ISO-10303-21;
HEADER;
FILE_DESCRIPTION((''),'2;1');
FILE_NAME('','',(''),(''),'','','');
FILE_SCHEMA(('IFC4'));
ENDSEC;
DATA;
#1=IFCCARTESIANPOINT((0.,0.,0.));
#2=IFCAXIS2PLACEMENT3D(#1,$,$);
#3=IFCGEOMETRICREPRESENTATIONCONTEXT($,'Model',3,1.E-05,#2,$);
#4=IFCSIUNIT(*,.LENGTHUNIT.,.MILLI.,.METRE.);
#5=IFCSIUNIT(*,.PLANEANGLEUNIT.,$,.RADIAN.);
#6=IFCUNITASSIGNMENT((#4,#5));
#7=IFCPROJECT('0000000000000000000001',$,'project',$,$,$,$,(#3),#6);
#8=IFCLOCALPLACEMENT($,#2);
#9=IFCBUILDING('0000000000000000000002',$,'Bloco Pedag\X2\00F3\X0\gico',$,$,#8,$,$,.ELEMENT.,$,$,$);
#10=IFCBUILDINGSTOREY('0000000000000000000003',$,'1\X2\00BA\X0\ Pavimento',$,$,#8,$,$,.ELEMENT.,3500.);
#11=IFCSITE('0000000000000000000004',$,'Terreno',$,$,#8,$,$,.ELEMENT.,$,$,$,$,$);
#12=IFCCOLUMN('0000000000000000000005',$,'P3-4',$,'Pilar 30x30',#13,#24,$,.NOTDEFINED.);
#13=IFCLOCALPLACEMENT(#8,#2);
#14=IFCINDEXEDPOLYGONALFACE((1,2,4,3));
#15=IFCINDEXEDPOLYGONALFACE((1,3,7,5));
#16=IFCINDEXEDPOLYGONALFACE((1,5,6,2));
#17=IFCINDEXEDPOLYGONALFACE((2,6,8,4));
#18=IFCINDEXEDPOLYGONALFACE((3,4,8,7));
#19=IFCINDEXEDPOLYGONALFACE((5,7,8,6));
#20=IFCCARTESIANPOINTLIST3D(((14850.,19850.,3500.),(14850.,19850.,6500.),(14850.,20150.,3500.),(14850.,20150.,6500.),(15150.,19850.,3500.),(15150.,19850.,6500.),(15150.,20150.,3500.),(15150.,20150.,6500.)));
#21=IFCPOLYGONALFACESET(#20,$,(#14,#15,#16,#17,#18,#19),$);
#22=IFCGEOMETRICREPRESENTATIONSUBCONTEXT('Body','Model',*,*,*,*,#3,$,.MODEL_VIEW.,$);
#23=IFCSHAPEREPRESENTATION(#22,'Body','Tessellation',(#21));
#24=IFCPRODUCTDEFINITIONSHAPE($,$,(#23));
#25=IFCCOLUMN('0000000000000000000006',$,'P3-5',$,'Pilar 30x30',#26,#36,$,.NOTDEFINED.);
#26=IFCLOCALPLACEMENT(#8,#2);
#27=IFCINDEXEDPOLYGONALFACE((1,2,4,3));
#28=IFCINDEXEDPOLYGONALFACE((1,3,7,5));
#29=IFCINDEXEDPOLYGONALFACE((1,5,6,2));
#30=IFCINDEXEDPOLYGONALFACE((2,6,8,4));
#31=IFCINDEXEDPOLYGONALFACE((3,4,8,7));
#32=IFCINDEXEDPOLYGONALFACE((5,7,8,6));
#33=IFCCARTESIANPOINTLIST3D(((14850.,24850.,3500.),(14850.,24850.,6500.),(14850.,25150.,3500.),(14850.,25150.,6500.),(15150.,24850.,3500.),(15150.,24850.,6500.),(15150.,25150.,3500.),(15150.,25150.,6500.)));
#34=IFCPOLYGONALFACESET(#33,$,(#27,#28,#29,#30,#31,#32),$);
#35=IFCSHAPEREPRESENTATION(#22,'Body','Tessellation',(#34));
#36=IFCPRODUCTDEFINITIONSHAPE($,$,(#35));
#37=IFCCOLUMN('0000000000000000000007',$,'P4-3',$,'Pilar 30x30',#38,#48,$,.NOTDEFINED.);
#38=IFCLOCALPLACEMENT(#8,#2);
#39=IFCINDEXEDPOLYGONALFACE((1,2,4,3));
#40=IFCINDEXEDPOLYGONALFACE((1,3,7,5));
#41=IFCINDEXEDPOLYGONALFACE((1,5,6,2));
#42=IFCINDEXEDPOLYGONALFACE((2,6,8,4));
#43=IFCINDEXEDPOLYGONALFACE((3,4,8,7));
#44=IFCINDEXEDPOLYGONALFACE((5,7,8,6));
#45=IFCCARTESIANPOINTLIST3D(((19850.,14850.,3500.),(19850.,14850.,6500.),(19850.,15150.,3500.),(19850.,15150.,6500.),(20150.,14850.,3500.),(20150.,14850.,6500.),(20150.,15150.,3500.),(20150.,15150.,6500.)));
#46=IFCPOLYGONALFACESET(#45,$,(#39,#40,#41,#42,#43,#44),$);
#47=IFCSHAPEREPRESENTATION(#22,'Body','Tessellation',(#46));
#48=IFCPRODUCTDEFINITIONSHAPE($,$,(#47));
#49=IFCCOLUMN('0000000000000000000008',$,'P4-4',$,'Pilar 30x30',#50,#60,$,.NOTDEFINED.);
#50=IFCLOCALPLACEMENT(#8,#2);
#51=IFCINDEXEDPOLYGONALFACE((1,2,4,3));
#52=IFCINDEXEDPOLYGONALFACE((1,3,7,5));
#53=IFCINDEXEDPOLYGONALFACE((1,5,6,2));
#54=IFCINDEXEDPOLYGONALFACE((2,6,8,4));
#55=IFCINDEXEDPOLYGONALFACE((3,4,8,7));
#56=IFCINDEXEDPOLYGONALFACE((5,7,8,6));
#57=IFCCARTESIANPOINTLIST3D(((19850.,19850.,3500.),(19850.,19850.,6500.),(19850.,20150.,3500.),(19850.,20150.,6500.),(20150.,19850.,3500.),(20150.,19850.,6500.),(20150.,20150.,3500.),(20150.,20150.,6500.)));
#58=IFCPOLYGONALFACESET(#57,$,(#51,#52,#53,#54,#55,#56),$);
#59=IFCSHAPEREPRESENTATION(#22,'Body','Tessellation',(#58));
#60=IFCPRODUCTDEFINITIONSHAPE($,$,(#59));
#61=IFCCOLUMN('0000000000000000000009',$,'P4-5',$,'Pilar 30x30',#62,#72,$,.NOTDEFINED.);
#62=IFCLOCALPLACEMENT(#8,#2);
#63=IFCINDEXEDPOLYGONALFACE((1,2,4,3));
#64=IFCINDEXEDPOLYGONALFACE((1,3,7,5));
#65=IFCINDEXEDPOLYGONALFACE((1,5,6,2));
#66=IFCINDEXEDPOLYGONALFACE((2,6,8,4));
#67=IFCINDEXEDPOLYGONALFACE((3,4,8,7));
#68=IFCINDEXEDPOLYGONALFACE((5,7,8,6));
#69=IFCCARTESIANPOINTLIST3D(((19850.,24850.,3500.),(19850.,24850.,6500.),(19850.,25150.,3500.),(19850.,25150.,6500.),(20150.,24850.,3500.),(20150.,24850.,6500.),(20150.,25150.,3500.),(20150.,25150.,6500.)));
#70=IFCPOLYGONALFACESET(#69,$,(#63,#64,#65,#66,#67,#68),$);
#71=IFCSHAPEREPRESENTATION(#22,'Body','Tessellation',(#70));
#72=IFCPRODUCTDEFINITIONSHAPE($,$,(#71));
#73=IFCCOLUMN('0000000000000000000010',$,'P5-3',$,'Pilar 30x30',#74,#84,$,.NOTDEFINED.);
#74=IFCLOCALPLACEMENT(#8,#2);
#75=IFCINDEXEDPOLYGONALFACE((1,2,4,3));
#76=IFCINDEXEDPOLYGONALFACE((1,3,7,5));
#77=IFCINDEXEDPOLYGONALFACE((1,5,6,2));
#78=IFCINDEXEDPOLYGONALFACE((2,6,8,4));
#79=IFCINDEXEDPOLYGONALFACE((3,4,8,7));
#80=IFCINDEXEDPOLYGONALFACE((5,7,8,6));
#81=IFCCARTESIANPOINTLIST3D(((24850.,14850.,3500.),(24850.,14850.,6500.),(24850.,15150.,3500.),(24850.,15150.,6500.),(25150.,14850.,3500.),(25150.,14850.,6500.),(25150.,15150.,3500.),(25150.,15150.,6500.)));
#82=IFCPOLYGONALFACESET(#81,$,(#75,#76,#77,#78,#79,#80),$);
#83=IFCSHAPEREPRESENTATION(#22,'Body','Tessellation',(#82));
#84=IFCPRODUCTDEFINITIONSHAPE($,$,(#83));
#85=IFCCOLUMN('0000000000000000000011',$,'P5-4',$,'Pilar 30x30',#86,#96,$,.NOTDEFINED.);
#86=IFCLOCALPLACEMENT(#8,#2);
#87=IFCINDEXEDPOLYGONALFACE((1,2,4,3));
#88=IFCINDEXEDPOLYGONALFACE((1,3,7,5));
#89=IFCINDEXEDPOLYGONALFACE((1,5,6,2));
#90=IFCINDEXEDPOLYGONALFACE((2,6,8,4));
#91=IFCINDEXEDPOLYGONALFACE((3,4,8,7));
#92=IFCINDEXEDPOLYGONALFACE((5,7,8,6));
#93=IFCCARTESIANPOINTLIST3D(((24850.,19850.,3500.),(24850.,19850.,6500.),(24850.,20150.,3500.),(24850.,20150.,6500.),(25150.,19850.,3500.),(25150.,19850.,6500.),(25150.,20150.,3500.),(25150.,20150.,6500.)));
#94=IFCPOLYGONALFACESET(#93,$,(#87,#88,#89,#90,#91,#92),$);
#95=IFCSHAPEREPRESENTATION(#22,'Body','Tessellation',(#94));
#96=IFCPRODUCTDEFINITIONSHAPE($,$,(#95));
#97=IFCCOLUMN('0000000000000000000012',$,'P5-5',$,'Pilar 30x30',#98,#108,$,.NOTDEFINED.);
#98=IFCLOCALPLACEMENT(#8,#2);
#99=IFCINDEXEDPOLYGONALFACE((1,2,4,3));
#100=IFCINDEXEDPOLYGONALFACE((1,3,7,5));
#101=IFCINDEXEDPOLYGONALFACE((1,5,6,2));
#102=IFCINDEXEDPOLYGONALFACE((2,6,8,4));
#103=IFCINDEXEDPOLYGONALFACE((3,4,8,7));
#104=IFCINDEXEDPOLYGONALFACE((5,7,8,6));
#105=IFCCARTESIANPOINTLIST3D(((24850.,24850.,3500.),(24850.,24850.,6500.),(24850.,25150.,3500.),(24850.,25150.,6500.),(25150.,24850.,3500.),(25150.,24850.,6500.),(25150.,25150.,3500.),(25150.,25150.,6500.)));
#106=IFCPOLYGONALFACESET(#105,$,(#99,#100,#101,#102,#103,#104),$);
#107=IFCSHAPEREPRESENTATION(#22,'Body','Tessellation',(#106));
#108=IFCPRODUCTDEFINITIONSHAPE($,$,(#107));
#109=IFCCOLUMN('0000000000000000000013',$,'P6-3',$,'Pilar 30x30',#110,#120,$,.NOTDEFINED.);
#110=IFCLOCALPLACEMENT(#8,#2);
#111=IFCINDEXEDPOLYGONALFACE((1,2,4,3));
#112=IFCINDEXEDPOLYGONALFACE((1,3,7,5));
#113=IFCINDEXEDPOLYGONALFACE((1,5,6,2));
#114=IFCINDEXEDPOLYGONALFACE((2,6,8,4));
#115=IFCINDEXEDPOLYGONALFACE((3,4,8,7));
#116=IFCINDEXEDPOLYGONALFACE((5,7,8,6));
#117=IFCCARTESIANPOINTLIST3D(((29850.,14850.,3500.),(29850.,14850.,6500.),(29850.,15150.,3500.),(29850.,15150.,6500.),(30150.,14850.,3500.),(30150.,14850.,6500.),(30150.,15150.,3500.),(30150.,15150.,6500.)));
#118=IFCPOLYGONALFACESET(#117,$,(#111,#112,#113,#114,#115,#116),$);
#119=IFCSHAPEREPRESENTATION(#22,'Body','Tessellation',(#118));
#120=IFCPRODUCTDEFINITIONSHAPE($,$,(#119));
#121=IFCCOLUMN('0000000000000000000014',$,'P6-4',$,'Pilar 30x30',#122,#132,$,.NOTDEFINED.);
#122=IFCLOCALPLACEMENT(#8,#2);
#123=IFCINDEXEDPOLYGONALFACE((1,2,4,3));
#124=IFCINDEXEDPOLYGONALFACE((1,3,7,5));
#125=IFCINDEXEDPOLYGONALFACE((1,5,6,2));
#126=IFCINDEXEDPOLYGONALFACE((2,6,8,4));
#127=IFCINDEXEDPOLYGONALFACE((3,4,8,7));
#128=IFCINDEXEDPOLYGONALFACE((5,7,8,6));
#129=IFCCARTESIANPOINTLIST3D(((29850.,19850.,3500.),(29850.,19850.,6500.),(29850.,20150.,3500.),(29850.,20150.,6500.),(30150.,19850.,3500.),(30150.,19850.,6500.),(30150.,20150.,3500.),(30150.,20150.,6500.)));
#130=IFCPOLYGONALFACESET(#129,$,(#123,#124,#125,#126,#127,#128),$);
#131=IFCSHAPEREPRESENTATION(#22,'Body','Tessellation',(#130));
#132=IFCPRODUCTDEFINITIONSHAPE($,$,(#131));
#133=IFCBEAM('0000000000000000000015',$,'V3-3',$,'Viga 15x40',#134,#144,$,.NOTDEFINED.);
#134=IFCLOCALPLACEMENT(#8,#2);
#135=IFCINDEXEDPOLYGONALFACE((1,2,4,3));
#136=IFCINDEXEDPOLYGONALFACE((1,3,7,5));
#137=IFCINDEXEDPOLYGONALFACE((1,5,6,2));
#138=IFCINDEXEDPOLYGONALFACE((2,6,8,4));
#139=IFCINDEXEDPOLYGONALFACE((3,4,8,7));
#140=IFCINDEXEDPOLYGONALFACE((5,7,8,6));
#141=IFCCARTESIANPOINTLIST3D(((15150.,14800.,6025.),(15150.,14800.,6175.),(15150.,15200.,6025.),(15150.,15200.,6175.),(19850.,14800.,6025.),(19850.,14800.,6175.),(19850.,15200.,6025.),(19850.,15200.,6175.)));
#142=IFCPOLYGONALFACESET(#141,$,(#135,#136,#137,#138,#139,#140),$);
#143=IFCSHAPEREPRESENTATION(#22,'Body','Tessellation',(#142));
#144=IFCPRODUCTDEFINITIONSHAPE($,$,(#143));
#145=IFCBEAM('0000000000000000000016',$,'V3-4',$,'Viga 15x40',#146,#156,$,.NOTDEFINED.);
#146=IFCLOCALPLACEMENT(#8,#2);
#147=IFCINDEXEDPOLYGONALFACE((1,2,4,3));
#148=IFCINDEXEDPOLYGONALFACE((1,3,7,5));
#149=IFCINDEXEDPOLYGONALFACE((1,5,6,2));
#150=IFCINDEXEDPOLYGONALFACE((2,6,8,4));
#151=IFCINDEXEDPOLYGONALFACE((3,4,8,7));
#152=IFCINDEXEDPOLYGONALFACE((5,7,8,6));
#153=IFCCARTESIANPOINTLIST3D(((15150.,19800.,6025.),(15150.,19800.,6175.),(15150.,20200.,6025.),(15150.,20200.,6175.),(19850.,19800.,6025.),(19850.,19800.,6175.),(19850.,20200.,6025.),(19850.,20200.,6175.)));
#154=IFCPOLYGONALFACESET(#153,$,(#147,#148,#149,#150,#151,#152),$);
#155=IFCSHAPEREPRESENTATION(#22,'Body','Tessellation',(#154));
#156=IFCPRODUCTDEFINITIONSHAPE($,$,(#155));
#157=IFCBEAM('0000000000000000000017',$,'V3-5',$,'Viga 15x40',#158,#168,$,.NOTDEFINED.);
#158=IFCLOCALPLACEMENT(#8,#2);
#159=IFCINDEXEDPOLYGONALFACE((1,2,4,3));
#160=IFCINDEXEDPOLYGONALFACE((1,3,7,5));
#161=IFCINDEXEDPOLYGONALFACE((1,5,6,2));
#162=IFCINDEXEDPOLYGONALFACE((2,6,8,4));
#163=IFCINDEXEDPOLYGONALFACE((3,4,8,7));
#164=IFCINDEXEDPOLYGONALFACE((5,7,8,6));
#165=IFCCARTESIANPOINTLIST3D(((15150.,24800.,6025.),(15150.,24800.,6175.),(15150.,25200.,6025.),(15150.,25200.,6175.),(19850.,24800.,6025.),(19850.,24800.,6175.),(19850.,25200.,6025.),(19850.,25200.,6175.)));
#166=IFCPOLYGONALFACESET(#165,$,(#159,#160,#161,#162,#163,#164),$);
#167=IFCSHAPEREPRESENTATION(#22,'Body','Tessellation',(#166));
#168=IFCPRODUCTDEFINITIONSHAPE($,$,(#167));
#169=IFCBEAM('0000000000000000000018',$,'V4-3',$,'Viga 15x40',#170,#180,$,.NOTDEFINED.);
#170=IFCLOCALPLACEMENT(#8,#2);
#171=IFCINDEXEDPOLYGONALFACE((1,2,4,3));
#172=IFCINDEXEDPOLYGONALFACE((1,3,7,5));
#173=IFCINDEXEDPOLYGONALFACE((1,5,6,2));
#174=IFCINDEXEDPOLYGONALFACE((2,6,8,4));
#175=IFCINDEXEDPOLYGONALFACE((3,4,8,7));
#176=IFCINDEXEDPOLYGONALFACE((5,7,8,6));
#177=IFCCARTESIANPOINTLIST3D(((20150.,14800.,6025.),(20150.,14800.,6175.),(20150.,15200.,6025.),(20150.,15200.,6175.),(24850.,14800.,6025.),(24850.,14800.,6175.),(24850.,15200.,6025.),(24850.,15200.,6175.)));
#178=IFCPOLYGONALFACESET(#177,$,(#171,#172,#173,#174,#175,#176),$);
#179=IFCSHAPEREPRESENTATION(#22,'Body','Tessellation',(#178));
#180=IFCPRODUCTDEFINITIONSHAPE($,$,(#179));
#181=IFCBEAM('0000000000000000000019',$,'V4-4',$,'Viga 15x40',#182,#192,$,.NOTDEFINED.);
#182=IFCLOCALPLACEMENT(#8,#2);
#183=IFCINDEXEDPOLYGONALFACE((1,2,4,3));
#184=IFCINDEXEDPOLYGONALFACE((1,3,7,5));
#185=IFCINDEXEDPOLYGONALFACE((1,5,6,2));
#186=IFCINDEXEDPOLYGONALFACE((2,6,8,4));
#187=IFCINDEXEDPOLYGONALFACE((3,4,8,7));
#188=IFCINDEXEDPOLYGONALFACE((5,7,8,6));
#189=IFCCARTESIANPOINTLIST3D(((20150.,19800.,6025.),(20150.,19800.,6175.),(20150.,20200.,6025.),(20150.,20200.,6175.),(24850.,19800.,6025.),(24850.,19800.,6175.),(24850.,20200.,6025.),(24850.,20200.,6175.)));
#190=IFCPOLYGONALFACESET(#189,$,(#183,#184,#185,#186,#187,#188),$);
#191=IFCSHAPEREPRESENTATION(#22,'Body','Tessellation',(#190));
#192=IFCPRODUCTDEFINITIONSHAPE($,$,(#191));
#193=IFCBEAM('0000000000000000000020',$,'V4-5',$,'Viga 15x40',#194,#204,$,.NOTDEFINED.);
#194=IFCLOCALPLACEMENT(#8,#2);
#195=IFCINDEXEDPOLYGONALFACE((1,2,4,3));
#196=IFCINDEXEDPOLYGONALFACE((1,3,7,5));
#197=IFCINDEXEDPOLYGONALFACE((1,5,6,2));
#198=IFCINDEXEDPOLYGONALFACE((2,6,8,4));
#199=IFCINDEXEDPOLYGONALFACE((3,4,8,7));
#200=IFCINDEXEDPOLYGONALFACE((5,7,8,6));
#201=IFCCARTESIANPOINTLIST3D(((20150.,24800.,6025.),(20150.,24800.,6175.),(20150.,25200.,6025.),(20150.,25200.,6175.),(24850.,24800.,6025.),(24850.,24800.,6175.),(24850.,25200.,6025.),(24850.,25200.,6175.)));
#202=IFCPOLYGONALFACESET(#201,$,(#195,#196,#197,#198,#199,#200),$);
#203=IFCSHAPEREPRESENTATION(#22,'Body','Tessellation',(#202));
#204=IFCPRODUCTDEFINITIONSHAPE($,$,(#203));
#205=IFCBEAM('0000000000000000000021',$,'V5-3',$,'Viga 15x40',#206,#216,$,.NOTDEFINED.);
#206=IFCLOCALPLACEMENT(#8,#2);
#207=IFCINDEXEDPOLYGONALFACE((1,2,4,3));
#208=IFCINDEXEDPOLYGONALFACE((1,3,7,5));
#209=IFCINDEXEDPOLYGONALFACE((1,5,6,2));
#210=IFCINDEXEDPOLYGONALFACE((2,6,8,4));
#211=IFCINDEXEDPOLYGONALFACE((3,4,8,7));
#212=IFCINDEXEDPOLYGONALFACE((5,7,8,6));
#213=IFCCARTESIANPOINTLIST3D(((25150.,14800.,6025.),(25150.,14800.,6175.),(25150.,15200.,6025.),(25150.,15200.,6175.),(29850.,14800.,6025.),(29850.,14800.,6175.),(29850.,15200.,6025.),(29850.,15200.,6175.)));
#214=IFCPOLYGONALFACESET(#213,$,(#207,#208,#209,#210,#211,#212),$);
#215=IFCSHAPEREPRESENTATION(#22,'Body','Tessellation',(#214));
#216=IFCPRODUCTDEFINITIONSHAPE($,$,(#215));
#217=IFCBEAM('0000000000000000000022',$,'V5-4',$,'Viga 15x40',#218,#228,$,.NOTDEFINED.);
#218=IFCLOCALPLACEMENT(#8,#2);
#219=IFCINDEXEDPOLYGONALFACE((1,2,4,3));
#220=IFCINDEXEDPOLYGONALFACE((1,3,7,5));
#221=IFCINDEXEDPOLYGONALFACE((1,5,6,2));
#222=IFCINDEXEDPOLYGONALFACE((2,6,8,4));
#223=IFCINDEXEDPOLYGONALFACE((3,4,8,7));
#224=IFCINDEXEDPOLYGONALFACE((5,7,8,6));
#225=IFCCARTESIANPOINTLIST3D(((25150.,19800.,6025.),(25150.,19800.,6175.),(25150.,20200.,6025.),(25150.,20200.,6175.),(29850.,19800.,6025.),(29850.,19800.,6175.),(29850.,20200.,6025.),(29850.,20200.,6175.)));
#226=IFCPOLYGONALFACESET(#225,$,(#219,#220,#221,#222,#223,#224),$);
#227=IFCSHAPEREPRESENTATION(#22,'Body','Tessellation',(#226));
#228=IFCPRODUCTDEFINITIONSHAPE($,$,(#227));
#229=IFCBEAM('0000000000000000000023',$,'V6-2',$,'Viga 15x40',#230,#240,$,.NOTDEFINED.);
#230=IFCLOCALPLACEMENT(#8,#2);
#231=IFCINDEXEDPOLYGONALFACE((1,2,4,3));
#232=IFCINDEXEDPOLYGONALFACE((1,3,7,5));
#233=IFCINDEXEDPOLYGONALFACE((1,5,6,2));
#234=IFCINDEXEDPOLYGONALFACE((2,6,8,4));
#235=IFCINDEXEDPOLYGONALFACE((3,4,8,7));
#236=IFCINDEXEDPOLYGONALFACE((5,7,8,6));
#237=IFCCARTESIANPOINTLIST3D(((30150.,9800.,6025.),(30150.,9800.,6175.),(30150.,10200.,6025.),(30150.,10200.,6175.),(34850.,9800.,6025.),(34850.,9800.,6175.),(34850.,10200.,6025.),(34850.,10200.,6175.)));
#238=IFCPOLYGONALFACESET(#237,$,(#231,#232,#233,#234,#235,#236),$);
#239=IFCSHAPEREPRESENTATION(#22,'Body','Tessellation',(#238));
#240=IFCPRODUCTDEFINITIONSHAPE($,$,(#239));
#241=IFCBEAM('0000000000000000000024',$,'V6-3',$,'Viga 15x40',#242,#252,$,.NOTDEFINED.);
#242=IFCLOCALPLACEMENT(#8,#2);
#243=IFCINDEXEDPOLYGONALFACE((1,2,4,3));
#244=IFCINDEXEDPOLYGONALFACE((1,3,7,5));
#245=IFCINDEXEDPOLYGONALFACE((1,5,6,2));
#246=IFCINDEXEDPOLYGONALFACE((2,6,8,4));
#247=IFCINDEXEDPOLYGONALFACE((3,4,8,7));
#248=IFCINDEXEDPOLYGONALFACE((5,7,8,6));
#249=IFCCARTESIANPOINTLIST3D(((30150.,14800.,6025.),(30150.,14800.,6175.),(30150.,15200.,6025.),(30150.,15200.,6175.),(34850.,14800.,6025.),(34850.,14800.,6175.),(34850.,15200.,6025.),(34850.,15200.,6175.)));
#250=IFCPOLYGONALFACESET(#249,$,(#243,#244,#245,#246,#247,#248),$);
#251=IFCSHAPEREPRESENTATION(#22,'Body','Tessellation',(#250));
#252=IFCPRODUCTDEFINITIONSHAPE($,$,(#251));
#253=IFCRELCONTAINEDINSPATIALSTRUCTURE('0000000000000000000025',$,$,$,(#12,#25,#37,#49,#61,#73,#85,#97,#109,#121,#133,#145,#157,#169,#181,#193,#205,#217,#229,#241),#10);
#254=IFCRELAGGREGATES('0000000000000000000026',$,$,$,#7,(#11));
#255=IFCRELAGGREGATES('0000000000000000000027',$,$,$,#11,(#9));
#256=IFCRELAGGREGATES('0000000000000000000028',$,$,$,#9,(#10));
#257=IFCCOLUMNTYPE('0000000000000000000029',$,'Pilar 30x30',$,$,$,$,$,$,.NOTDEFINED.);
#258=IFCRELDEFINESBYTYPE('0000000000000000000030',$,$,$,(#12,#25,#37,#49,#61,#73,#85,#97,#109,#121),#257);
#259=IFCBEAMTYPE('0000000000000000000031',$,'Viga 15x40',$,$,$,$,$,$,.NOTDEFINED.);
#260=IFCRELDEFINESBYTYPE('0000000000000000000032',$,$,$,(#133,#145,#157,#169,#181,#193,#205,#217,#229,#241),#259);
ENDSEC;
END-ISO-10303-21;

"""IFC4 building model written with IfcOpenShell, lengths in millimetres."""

from ifc_helpers import new_model, si_unit, frame, origin, origin_2d, place, context, subcontext, project, spatial, rectangle, extrude, type_object, element, save


model = new_model("IFC4")

# Units and contexts
model_context = context("Model", 3, precision=1e-05, world=origin())
body_context = subcontext(model_context, "Body", "Model", "MODEL_VIEW")
ifc_project = project(units=[si_unit("LENGTHUNIT", "METRE", prefix="MILLI"), si_unit("PLANEANGLEUNIT", "RADIAN")], contexts=[model_context])

# Site, building, storey
placement = place(None, origin())
site = spatial("IfcSite", under=ifc_project, at=placement, Name="Terreno", CompositionType="ELEMENT")
building = spatial("IfcBuilding", under=site, at=placement, Name="Bloco Pedagógico", CompositionType="ELEMENT")
storey = spatial("IfcBuildingStorey", under=building, at=placement, Name="1º Pavimento", CompositionType="ELEMENT", Elevation=3500.0)

# Columns
column_type = type_object("IfcColumnType", Name="Pilar 30x30", PredefinedType="NOTDEFINED")
for number, where, z_axis, x_axis, name in (
    (1, (15000.0, 20000.0, 3500.0), (0.0, 0.0, 1.0), (1.0, 0.0, 0.0), "P3-4"),
    (2, (15000.0, 25000.0, 3500.0), (0.0, 0.0, 1.0), (1.0, 0.0, 0.0), "P3-5"),
    (3, (20000.0, 15000.0, 3500.0), (0.0, 0.0, 1.0), (1.0, 0.0, 0.0), "P4-3"),
    (4, (20000.0, 20000.0, 3500.0), (0.0, 0.0, 1.0), (1.0, 0.0, 0.0), "P4-4"),
    (5, (20000.0, 25000.0, 3500.0), (0.0, 0.0, 1.0), (1.0, 0.0, 0.0), "P4-5"),
    (6, (25000.0, 15000.0, 3500.0), (0.0, 0.0, 1.0), (1.0, 0.0, 0.0), "P5-3"),
    (7, (25000.0, 20000.0, 3500.0), (0.0, 0.0, 1.0), (1.0, 0.0, 0.0), "P5-4"),
    (8, (25000.0, 25000.0, 3500.0), (0.0, 0.0, 1.0), (1.0, 0.0, 0.0), "P5-5"),
    (9, (30000.0, 15000.0, 3500.0), (0.0, 0.0, 1.0), (1.0, 0.0, 0.0), "P6-3"),
    (10, (30000.0, 20000.0, 3500.0), (0.0, 0.0, 1.0), (1.0, 0.0, 0.0), "P6-4"),
):
    element("IfcColumn", number, at=place(None, frame(where, z_axis=z_axis, x_axis=x_axis)), inside=storey, type_object=column_type, Name=name, ObjectType="Pilar 30x30", PredefinedType="NOTDEFINED", context=body_context, shape_type="SweptSolid", body=[
        extrude(rectangle(XDim=300.0, YDim=300.0, at=origin_2d()), None, (0.0, 0.0, 1.0), 3000.0),
    ])

# Beams
beam_type = type_object("IfcBeamType", Name="Viga 15x40", PredefinedType="NOTDEFINED")
for number, where, z_axis, x_axis, name in (
    (11, (15150.0, 15000.0, 6100.0), (1.0, 0.0, 0.0), (0.0, 1.0, 0.0), "V3-3"),
    (12, (15150.0, 20000.0, 6100.0), (1.0, 0.0, 0.0), (0.0, 1.0, 0.0), "V3-4"),
    (13, (15150.0, 25000.0, 6100.0), (1.0, 0.0, 0.0), (0.0, 1.0, 0.0), "V3-5"),
    (14, (20150.0, 15000.0, 6100.0), (1.0, 0.0, 0.0), (0.0, 1.0, 0.0), "V4-3"),
    (15, (20150.0, 20000.0, 6100.0), (1.0, 0.0, 0.0), (0.0, 1.0, 0.0), "V4-4"),
    (16, (20150.0, 25000.0, 6100.0), (1.0, 0.0, 0.0), (0.0, 1.0, 0.0), "V4-5"),
    (17, (25150.0, 15000.0, 6100.0), (1.0, 0.0, 0.0), (0.0, 1.0, 0.0), "V5-3"),
    (18, (25150.0, 20000.0, 6100.0), (1.0, 0.0, 0.0), (0.0, 1.0, 0.0), "V5-4"),
    (19, (30150.0, 10000.0, 6100.0), (1.0, 0.0, 0.0), (0.0, 1.0, 0.0), "V6-2"),
    (20, (30150.0, 15000.0, 6100.0), (1.0, 0.0, 0.0), (0.0, 1.0, 0.0), "V6-3"),
):
    element("IfcBeam", number, at=place(None, frame(where, z_axis=z_axis, x_axis=x_axis)), inside=storey, type_object=beam_type, Name=name, ObjectType="Viga 15x40", PredefinedType="NOTDEFINED", context=body_context, shape_type="SweptSolid", body=[
        extrude(rectangle(XDim=400.0, YDim=150.0, at=origin_2d()), None, (0.0, 0.0, 1.0), 4700.0),
    ])

save(model, "model.ifc")
